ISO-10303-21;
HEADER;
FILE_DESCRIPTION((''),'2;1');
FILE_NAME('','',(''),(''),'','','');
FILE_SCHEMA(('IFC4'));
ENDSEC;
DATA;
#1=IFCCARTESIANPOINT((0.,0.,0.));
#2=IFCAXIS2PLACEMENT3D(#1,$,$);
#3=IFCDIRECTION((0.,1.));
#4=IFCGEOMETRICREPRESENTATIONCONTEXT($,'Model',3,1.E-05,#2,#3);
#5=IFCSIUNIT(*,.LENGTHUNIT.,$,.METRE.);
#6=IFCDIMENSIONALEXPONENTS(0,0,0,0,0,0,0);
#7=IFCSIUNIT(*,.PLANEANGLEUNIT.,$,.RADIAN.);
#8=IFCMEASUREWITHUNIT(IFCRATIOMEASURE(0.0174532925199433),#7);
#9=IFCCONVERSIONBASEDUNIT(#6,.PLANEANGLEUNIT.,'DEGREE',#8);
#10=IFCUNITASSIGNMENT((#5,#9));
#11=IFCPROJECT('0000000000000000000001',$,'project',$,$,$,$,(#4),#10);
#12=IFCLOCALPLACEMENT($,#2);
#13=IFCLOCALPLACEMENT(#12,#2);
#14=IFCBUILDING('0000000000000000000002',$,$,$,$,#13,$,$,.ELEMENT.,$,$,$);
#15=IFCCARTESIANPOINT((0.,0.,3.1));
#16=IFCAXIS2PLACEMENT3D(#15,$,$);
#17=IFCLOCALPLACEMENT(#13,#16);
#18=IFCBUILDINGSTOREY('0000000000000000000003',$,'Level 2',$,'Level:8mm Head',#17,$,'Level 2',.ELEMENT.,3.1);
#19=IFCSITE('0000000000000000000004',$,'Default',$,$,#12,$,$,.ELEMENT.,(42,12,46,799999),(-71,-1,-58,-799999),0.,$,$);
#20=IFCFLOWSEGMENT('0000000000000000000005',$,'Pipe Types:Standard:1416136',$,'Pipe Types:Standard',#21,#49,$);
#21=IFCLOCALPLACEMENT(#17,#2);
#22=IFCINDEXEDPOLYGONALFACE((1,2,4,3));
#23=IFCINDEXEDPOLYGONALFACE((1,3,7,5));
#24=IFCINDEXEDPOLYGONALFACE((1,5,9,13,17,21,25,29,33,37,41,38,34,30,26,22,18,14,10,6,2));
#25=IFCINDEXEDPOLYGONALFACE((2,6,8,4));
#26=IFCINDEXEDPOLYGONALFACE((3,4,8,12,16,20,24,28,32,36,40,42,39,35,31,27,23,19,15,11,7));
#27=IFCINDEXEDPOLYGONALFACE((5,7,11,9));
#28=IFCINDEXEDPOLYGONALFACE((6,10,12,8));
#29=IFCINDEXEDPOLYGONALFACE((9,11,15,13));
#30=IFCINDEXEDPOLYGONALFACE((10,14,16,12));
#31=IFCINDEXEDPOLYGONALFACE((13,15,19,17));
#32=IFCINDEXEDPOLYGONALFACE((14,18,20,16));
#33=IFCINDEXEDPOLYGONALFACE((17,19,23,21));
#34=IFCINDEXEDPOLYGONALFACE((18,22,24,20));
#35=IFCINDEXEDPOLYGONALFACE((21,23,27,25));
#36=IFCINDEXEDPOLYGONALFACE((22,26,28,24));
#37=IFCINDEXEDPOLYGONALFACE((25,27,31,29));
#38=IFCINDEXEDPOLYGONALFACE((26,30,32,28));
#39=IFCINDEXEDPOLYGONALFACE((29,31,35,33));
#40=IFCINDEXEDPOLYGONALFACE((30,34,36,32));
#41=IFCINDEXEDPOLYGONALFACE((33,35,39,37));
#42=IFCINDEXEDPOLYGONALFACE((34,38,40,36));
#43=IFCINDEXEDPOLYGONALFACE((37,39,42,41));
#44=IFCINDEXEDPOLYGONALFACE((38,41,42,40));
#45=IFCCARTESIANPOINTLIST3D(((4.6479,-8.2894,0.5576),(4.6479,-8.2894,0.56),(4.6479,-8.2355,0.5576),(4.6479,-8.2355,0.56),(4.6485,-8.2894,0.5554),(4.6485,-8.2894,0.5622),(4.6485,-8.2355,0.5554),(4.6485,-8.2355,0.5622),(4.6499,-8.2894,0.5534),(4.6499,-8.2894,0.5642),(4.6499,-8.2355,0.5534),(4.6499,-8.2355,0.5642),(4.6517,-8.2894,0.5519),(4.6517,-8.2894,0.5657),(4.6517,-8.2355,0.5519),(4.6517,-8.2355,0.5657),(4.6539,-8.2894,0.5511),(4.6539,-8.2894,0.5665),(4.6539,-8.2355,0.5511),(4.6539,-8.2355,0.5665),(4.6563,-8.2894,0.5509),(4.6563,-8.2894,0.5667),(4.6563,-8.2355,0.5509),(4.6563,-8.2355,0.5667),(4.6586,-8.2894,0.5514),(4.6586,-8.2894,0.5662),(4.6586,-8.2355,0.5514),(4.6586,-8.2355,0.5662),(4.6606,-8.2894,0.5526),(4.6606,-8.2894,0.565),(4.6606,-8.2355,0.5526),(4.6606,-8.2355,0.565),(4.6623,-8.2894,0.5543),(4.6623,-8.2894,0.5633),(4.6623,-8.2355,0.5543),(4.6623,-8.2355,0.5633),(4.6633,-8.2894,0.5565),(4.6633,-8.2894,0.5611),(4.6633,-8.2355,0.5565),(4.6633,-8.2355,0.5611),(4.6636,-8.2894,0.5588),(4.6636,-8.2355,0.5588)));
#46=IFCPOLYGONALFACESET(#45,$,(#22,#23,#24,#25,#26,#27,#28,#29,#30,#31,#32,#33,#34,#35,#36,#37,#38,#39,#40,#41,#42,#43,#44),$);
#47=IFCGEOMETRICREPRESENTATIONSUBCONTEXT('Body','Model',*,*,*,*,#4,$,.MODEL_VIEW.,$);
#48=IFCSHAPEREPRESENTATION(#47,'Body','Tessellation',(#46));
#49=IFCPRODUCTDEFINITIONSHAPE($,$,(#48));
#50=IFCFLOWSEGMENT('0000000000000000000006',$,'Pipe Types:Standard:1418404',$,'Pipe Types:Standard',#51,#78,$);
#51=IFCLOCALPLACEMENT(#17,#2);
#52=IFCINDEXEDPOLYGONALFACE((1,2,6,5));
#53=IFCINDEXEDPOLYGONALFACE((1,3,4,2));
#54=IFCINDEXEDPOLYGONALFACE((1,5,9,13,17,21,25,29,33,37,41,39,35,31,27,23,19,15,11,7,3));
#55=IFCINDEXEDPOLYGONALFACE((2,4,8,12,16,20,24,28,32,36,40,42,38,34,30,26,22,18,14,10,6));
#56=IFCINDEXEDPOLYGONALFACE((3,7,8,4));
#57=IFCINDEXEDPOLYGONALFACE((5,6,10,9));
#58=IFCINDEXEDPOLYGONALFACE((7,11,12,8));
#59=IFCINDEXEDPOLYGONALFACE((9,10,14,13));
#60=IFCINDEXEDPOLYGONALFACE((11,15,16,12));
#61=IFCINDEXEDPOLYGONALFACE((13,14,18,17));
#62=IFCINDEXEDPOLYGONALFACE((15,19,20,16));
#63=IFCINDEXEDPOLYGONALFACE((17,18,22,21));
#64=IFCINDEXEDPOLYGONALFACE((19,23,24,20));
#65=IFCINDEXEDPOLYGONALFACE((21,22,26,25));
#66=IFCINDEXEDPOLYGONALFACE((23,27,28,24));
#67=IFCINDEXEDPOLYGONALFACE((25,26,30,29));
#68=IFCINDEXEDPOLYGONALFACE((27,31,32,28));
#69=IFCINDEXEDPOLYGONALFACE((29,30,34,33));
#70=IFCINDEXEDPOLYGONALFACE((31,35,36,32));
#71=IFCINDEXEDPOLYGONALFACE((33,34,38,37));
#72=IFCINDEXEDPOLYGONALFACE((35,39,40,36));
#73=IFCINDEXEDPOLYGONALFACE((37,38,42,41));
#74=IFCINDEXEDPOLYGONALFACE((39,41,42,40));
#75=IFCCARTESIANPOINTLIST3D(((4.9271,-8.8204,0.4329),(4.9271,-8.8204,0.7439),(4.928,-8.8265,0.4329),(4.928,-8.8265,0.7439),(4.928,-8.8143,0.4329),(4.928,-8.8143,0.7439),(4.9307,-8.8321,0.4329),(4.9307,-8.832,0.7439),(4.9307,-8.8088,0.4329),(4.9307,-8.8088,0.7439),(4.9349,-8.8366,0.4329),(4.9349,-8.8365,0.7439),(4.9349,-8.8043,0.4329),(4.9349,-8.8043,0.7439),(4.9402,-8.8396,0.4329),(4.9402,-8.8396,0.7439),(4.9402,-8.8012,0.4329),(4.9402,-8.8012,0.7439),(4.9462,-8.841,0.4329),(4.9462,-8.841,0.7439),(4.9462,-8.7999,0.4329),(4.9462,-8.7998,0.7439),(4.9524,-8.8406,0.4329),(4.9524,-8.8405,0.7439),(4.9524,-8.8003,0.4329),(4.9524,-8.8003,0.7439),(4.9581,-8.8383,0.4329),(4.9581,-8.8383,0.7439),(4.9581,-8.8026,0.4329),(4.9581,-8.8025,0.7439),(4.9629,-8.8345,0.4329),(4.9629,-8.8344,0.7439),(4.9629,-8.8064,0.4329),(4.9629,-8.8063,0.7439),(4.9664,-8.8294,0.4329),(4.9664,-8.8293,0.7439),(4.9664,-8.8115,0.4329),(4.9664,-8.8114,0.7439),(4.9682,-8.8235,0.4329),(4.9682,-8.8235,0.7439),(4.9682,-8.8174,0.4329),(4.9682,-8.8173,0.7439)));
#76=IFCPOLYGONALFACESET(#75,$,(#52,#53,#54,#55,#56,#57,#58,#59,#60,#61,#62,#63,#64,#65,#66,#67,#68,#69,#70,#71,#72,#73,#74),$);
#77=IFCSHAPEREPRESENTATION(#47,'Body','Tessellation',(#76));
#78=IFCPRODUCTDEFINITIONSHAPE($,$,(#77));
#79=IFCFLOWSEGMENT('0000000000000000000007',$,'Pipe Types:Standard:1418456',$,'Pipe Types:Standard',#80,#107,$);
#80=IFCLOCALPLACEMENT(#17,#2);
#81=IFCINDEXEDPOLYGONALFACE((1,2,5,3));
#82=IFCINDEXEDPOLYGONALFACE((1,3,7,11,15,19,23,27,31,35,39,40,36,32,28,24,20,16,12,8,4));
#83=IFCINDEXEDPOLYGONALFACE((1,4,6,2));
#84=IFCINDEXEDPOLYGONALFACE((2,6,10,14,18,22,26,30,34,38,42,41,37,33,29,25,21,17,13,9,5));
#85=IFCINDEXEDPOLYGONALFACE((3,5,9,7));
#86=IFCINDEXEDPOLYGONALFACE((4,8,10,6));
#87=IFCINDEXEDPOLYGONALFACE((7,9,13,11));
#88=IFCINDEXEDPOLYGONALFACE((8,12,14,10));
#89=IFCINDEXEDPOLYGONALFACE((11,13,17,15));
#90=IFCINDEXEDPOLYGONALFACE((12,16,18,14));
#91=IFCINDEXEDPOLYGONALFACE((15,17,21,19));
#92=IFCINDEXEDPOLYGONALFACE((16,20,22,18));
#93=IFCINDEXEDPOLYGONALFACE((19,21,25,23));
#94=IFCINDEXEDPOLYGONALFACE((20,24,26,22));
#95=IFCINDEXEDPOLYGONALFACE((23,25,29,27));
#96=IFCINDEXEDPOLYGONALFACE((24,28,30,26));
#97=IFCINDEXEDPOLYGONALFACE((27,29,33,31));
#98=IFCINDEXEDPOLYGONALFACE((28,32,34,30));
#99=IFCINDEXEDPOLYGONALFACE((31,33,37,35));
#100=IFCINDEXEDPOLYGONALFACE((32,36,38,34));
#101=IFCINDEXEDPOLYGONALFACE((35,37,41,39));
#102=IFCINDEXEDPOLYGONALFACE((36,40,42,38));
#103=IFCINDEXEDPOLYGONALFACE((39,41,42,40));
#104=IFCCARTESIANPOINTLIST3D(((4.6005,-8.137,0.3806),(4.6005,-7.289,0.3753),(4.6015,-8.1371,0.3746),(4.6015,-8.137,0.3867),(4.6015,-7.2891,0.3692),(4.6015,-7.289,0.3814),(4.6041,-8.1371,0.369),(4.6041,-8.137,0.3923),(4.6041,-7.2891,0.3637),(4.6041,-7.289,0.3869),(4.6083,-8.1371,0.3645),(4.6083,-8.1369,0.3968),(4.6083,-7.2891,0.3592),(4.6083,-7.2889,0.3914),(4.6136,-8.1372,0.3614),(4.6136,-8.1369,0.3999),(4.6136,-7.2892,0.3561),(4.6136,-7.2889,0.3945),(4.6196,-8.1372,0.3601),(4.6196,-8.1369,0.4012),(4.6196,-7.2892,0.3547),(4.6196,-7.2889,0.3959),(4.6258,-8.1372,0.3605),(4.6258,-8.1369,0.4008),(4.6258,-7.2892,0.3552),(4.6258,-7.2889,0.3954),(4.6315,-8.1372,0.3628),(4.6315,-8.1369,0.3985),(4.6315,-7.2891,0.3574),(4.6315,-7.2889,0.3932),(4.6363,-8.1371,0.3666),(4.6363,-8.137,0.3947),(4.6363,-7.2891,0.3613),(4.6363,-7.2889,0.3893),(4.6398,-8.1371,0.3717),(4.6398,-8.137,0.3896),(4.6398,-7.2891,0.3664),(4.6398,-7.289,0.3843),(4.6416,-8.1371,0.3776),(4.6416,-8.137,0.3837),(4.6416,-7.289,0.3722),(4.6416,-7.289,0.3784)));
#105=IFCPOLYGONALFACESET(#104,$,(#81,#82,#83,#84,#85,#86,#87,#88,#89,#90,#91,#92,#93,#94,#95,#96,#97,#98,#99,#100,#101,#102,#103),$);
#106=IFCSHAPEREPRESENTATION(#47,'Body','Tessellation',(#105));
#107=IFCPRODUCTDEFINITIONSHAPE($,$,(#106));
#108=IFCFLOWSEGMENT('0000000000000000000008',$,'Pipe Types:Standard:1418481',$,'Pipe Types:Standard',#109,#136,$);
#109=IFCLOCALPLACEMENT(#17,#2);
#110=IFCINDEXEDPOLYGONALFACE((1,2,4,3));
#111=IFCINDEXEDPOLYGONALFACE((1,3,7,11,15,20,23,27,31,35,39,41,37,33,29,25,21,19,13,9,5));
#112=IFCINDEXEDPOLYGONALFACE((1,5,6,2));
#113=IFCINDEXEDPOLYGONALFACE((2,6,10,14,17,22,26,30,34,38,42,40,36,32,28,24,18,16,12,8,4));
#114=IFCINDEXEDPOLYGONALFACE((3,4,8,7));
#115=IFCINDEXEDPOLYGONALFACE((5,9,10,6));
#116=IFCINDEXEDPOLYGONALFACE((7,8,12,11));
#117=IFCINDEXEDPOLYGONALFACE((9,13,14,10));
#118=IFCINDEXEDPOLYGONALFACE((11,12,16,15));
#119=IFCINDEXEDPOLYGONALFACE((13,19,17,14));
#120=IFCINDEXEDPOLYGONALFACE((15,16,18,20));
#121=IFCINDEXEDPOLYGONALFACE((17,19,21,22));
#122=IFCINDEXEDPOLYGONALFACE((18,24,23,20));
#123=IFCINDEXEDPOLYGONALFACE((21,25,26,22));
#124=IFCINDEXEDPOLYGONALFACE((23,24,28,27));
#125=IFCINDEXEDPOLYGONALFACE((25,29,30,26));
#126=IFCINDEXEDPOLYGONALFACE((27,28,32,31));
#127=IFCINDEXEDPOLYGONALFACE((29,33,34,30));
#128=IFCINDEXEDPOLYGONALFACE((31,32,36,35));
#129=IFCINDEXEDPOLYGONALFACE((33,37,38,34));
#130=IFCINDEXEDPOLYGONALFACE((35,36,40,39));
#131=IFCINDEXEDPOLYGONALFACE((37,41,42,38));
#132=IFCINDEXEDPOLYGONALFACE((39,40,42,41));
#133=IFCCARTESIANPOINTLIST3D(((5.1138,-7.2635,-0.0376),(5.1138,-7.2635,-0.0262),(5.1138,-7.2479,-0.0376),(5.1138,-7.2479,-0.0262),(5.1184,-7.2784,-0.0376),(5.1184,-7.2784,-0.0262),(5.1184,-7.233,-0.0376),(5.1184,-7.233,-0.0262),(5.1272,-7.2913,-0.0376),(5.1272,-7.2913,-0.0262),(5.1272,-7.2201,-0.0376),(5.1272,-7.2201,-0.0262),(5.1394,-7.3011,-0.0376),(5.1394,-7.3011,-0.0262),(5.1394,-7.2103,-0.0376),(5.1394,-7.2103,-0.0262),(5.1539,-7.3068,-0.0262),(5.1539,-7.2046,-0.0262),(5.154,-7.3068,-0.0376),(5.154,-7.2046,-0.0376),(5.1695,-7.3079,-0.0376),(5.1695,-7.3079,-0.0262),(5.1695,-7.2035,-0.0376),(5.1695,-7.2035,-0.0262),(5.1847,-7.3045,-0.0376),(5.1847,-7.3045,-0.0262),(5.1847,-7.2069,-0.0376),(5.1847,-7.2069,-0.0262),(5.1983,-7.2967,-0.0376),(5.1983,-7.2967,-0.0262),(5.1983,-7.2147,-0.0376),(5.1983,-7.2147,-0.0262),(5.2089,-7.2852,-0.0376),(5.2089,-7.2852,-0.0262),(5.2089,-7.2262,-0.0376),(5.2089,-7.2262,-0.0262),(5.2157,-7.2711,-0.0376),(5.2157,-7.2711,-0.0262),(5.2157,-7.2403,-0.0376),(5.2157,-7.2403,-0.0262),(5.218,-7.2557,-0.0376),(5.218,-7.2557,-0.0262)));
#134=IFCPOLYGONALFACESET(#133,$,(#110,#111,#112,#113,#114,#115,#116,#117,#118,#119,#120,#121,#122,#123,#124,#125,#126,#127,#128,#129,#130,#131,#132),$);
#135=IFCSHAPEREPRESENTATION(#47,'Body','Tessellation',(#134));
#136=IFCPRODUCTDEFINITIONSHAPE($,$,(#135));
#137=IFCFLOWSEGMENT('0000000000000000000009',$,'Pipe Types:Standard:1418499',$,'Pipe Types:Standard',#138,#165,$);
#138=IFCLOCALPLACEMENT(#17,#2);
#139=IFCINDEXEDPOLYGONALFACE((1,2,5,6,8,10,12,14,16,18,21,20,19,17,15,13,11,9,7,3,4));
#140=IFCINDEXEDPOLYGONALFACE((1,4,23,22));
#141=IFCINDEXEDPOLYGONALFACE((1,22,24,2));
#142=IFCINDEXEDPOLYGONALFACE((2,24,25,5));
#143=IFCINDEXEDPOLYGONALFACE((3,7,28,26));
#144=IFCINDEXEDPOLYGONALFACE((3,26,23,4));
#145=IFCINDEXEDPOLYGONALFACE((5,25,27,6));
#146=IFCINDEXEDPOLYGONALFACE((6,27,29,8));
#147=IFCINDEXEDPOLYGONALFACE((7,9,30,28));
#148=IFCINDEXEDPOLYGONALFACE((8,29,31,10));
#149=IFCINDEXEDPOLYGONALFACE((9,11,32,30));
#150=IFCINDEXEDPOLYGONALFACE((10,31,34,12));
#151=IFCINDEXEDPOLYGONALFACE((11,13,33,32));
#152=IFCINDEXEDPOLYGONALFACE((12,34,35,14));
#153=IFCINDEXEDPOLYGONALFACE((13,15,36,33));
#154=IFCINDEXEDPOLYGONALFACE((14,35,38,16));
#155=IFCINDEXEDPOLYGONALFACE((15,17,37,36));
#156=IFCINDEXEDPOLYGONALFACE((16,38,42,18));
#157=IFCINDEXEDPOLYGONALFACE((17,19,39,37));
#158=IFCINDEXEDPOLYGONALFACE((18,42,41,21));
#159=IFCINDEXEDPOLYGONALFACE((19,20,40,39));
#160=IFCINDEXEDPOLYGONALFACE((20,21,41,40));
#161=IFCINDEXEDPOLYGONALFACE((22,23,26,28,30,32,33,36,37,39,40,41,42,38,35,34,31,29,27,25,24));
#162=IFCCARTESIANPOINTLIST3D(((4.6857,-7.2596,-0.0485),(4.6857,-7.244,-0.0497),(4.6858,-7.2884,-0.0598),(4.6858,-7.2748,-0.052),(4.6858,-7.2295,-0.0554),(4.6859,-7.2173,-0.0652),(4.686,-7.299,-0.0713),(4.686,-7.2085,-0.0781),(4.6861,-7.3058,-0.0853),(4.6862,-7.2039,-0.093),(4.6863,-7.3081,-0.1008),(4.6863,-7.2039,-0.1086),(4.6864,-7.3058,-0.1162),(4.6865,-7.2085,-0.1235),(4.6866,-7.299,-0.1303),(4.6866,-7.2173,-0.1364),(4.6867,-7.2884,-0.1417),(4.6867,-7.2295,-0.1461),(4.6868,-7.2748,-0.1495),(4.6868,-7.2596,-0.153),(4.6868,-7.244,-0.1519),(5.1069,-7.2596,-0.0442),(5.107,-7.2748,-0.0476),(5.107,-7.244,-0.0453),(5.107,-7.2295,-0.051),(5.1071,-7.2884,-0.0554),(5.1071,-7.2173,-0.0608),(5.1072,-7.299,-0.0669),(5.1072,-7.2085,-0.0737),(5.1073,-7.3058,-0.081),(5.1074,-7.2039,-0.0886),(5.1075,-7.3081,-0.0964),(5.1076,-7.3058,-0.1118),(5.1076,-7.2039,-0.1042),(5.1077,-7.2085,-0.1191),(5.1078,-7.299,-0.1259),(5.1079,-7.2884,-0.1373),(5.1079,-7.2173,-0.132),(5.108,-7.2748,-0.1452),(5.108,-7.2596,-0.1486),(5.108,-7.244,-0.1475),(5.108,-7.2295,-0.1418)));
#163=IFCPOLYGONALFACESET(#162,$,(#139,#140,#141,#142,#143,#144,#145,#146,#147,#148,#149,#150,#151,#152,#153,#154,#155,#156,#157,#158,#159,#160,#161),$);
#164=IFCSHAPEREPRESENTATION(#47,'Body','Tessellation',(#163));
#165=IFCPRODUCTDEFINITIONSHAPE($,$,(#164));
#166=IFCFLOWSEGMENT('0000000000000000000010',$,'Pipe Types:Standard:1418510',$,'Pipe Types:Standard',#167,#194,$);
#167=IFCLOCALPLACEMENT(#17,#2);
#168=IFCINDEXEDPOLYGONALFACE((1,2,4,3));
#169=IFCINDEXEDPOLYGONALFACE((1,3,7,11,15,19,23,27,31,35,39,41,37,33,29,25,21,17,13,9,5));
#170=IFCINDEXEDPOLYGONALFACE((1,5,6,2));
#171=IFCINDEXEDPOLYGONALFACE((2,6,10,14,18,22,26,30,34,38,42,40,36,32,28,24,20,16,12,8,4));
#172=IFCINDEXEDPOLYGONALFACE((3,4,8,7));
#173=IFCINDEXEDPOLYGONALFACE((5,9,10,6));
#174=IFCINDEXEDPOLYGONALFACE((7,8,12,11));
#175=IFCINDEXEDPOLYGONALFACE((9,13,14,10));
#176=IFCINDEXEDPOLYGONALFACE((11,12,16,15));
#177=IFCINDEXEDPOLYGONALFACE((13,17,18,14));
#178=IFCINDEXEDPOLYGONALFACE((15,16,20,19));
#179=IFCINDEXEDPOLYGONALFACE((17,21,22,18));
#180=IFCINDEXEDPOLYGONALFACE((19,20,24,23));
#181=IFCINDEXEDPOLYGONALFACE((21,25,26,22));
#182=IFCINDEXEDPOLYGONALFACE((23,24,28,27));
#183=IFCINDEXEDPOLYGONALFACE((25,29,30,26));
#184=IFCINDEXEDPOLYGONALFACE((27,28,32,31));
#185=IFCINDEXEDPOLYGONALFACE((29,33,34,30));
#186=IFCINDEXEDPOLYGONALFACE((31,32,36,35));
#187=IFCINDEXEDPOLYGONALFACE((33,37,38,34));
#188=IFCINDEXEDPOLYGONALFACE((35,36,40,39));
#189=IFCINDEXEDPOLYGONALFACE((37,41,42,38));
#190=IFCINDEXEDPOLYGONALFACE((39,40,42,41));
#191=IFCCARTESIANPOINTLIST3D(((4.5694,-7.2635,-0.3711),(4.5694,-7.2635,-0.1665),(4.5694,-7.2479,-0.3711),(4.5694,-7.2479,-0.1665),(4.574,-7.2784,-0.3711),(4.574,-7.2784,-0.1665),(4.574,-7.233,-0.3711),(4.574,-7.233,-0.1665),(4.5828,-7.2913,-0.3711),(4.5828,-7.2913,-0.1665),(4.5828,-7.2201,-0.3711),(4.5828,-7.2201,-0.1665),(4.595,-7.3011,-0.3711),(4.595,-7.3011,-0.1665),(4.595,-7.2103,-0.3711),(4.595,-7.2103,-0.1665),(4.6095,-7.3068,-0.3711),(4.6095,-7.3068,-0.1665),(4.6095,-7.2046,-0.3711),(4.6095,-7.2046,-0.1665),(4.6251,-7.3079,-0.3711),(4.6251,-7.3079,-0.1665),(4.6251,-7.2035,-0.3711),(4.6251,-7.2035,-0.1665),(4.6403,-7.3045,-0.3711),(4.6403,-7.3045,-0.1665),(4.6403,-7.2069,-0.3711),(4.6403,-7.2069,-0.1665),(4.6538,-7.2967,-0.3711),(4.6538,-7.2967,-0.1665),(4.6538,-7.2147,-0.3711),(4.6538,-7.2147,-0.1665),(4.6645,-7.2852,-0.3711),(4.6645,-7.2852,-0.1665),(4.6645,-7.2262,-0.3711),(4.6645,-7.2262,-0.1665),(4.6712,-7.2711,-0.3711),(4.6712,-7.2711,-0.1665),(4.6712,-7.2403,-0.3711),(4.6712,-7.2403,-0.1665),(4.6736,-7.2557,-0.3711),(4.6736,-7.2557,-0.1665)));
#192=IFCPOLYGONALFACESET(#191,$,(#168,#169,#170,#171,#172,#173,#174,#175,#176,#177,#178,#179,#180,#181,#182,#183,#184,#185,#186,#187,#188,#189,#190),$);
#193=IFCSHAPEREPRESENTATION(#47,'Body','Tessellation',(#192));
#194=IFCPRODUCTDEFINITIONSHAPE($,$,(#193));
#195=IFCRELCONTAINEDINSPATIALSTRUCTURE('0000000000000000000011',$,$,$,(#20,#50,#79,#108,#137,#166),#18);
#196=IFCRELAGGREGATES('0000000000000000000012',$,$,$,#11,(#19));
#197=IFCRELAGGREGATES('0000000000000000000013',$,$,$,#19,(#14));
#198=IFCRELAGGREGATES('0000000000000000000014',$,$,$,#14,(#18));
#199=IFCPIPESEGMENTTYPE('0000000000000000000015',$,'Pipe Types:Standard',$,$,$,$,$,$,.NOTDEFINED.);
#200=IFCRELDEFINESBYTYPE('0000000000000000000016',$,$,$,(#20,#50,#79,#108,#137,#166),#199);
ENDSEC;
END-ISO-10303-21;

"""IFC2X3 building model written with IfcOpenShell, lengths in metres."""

from ifc_helpers import new_model, entity, si_unit, converted_unit, direction, frame, frame_2d, origin, origin_2d_with_axis, place, context, subcontext, project, spatial, circle, extrude, type_object, element, save


model = new_model("IFC2X3")

# Units and contexts
model_context = context("Model", 3, precision=1e-05, world=origin(), true_north=direction((0.0, 1.0)))
body_context = subcontext(model_context, "Body", "Model", "MODEL_VIEW")
ifc_project = project(units=[si_unit("LENGTHUNIT", "METRE"), converted_unit("PLANEANGLEUNIT", "DEGREE", entity("IfcRatioMeasure", 0.0174532925199433), si_unit("PLANEANGLEUNIT", "RADIAN"), dimensions=[0, 0, 0, 0, 0, 0, 0])], contexts=[model_context])

# Site, building, storey
site_placement = place(None, origin())
site = spatial("IfcSite", under=ifc_project, at=site_placement, Name="Default", CompositionType="ELEMENT", RefLatitude=(42, 12, 46, 799999), RefLongitude=(-71, -1, -58, -799999), RefElevation=0.0)
building_placement = place(site_placement, origin())
building = spatial("IfcBuilding", under=site, at=building_placement, CompositionType="ELEMENT")
storey_placement = place(building_placement, frame((0.0, 0.0, 3.1)))
storey = spatial("IfcBuildingStorey", under=building, at=storey_placement, Name="Level 2", ObjectType="Level:8mm Head", LongName="Level 2", CompositionType="ELEMENT", Elevation=3.1)

# Flow segments
pipe_segment_type = type_object("IfcPipeSegmentType", Name="Pipe Types:Standard", PredefinedType="NOTDEFINED")
flow_segment_1_placement = place(storey_placement, origin())
element("IfcFlowSegment", 1, at=flow_segment_1_placement, inside=storey, type_object=pipe_segment_type, Name="Pipe Types:Standard:1416136", ObjectType="Pipe Types:Standard", context=body_context, shape_type="SweptSolid", body=[
    extrude(circle(Radius=0.0079, at=frame_2d((0.0, 0.0), x_axis=(1.0, 0.0))), frame((4.6557, -8.2894, 0.5588), z_axis=(0.0, 1.0, 0.0), x_axis=(1.0, 0.0, 0.0)), (0.0, 0.0, 1.0), 0.0539),
])
flow_segment_2_placement = place(storey_placement, origin())
element("IfcFlowSegment", 2, at=flow_segment_2_placement, inside=storey, type_object=pipe_segment_type, Name="Pipe Types:Standard:1418404", ObjectType="Pipe Types:Standard", context=body_context, shape_type="SweptSolid", body=[
    extrude(circle(Radius=0.0206, at=origin_2d_with_axis()), frame((4.9478, -8.8204, 0.4329), z_axis=(0.0, 0.000149, 1.0), x_axis=(-1.0, 0.0, 0.0)), (0.0, 0.0, 1.0), 0.3109),
])
flow_segment_3_placement = place(storey_placement, origin())
element("IfcFlowSegment", 3, at=flow_segment_3_placement, inside=storey, type_object=pipe_segment_type, Name="Pipe Types:Standard:1418456", ObjectType="Pipe Types:Standard", context=body_context, shape_type="SweptSolid", body=[
    extrude(circle(Radius=0.0206, at=frame_2d((0.0, 0.0), x_axis=(1.0, 0.0))), frame((4.6212, -7.289, 0.3753), z_axis=(0.0, -0.99998, 0.006302), x_axis=(-1.0, 0.0, 0.0)), (0.0, 0.0, 1.0), 0.848),
])
flow_segment_4_placement = place(storey_placement, origin())
element("IfcFlowSegment", 4, at=flow_segment_4_placement, inside=storey, type_object=pipe_segment_type, Name="Pipe Types:Standard:1418481", ObjectType="Pipe Types:Standard", context=body_context, shape_type="SweptSolid", body=[
    extrude(circle(Radius=0.0524, at=origin_2d_with_axis()), frame((5.1656, -7.2557, -0.0376), z_axis=(-0.00046, 0.0, 1.0), x_axis=(1.0, 0.0, 0.00046)), (0.0, 0.0, 1.0), 0.0114),
])
flow_segment_5_placement = place(storey_placement, origin())
element("IfcFlowSegment", 5, at=flow_segment_5_placement, inside=storey, type_object=pipe_segment_type, Name="Pipe Types:Standard:1418499", ObjectType="Pipe Types:Standard", context=body_context, shape_type="SweptSolid", body=[
    extrude(circle(Radius=0.0524, at=origin_2d_with_axis()), frame((4.6863, -7.2557, -0.1008), z_axis=(0.999946, 0.0, 0.010416), x_axis=(0.0, -1.0, 0.0)), (0.0, 0.0, 1.0), 0.4212),
])
flow_segment_6_placement = place(storey_placement, origin())
element("IfcFlowSegment", 6, at=flow_segment_6_placement, inside=storey, type_object=pipe_segment_type, Name="Pipe Types:Standard:1418510", ObjectType="Pipe Types:Standard", context=body_context, shape_type="SweptSolid", body=[
    extrude(circle(Radius=0.0524, at=origin_2d_with_axis()), frame((4.6212, -7.2557, -0.3711)), (0.0, 0.0, 1.0), 0.2046),
])

save(model, "model.ifc")
